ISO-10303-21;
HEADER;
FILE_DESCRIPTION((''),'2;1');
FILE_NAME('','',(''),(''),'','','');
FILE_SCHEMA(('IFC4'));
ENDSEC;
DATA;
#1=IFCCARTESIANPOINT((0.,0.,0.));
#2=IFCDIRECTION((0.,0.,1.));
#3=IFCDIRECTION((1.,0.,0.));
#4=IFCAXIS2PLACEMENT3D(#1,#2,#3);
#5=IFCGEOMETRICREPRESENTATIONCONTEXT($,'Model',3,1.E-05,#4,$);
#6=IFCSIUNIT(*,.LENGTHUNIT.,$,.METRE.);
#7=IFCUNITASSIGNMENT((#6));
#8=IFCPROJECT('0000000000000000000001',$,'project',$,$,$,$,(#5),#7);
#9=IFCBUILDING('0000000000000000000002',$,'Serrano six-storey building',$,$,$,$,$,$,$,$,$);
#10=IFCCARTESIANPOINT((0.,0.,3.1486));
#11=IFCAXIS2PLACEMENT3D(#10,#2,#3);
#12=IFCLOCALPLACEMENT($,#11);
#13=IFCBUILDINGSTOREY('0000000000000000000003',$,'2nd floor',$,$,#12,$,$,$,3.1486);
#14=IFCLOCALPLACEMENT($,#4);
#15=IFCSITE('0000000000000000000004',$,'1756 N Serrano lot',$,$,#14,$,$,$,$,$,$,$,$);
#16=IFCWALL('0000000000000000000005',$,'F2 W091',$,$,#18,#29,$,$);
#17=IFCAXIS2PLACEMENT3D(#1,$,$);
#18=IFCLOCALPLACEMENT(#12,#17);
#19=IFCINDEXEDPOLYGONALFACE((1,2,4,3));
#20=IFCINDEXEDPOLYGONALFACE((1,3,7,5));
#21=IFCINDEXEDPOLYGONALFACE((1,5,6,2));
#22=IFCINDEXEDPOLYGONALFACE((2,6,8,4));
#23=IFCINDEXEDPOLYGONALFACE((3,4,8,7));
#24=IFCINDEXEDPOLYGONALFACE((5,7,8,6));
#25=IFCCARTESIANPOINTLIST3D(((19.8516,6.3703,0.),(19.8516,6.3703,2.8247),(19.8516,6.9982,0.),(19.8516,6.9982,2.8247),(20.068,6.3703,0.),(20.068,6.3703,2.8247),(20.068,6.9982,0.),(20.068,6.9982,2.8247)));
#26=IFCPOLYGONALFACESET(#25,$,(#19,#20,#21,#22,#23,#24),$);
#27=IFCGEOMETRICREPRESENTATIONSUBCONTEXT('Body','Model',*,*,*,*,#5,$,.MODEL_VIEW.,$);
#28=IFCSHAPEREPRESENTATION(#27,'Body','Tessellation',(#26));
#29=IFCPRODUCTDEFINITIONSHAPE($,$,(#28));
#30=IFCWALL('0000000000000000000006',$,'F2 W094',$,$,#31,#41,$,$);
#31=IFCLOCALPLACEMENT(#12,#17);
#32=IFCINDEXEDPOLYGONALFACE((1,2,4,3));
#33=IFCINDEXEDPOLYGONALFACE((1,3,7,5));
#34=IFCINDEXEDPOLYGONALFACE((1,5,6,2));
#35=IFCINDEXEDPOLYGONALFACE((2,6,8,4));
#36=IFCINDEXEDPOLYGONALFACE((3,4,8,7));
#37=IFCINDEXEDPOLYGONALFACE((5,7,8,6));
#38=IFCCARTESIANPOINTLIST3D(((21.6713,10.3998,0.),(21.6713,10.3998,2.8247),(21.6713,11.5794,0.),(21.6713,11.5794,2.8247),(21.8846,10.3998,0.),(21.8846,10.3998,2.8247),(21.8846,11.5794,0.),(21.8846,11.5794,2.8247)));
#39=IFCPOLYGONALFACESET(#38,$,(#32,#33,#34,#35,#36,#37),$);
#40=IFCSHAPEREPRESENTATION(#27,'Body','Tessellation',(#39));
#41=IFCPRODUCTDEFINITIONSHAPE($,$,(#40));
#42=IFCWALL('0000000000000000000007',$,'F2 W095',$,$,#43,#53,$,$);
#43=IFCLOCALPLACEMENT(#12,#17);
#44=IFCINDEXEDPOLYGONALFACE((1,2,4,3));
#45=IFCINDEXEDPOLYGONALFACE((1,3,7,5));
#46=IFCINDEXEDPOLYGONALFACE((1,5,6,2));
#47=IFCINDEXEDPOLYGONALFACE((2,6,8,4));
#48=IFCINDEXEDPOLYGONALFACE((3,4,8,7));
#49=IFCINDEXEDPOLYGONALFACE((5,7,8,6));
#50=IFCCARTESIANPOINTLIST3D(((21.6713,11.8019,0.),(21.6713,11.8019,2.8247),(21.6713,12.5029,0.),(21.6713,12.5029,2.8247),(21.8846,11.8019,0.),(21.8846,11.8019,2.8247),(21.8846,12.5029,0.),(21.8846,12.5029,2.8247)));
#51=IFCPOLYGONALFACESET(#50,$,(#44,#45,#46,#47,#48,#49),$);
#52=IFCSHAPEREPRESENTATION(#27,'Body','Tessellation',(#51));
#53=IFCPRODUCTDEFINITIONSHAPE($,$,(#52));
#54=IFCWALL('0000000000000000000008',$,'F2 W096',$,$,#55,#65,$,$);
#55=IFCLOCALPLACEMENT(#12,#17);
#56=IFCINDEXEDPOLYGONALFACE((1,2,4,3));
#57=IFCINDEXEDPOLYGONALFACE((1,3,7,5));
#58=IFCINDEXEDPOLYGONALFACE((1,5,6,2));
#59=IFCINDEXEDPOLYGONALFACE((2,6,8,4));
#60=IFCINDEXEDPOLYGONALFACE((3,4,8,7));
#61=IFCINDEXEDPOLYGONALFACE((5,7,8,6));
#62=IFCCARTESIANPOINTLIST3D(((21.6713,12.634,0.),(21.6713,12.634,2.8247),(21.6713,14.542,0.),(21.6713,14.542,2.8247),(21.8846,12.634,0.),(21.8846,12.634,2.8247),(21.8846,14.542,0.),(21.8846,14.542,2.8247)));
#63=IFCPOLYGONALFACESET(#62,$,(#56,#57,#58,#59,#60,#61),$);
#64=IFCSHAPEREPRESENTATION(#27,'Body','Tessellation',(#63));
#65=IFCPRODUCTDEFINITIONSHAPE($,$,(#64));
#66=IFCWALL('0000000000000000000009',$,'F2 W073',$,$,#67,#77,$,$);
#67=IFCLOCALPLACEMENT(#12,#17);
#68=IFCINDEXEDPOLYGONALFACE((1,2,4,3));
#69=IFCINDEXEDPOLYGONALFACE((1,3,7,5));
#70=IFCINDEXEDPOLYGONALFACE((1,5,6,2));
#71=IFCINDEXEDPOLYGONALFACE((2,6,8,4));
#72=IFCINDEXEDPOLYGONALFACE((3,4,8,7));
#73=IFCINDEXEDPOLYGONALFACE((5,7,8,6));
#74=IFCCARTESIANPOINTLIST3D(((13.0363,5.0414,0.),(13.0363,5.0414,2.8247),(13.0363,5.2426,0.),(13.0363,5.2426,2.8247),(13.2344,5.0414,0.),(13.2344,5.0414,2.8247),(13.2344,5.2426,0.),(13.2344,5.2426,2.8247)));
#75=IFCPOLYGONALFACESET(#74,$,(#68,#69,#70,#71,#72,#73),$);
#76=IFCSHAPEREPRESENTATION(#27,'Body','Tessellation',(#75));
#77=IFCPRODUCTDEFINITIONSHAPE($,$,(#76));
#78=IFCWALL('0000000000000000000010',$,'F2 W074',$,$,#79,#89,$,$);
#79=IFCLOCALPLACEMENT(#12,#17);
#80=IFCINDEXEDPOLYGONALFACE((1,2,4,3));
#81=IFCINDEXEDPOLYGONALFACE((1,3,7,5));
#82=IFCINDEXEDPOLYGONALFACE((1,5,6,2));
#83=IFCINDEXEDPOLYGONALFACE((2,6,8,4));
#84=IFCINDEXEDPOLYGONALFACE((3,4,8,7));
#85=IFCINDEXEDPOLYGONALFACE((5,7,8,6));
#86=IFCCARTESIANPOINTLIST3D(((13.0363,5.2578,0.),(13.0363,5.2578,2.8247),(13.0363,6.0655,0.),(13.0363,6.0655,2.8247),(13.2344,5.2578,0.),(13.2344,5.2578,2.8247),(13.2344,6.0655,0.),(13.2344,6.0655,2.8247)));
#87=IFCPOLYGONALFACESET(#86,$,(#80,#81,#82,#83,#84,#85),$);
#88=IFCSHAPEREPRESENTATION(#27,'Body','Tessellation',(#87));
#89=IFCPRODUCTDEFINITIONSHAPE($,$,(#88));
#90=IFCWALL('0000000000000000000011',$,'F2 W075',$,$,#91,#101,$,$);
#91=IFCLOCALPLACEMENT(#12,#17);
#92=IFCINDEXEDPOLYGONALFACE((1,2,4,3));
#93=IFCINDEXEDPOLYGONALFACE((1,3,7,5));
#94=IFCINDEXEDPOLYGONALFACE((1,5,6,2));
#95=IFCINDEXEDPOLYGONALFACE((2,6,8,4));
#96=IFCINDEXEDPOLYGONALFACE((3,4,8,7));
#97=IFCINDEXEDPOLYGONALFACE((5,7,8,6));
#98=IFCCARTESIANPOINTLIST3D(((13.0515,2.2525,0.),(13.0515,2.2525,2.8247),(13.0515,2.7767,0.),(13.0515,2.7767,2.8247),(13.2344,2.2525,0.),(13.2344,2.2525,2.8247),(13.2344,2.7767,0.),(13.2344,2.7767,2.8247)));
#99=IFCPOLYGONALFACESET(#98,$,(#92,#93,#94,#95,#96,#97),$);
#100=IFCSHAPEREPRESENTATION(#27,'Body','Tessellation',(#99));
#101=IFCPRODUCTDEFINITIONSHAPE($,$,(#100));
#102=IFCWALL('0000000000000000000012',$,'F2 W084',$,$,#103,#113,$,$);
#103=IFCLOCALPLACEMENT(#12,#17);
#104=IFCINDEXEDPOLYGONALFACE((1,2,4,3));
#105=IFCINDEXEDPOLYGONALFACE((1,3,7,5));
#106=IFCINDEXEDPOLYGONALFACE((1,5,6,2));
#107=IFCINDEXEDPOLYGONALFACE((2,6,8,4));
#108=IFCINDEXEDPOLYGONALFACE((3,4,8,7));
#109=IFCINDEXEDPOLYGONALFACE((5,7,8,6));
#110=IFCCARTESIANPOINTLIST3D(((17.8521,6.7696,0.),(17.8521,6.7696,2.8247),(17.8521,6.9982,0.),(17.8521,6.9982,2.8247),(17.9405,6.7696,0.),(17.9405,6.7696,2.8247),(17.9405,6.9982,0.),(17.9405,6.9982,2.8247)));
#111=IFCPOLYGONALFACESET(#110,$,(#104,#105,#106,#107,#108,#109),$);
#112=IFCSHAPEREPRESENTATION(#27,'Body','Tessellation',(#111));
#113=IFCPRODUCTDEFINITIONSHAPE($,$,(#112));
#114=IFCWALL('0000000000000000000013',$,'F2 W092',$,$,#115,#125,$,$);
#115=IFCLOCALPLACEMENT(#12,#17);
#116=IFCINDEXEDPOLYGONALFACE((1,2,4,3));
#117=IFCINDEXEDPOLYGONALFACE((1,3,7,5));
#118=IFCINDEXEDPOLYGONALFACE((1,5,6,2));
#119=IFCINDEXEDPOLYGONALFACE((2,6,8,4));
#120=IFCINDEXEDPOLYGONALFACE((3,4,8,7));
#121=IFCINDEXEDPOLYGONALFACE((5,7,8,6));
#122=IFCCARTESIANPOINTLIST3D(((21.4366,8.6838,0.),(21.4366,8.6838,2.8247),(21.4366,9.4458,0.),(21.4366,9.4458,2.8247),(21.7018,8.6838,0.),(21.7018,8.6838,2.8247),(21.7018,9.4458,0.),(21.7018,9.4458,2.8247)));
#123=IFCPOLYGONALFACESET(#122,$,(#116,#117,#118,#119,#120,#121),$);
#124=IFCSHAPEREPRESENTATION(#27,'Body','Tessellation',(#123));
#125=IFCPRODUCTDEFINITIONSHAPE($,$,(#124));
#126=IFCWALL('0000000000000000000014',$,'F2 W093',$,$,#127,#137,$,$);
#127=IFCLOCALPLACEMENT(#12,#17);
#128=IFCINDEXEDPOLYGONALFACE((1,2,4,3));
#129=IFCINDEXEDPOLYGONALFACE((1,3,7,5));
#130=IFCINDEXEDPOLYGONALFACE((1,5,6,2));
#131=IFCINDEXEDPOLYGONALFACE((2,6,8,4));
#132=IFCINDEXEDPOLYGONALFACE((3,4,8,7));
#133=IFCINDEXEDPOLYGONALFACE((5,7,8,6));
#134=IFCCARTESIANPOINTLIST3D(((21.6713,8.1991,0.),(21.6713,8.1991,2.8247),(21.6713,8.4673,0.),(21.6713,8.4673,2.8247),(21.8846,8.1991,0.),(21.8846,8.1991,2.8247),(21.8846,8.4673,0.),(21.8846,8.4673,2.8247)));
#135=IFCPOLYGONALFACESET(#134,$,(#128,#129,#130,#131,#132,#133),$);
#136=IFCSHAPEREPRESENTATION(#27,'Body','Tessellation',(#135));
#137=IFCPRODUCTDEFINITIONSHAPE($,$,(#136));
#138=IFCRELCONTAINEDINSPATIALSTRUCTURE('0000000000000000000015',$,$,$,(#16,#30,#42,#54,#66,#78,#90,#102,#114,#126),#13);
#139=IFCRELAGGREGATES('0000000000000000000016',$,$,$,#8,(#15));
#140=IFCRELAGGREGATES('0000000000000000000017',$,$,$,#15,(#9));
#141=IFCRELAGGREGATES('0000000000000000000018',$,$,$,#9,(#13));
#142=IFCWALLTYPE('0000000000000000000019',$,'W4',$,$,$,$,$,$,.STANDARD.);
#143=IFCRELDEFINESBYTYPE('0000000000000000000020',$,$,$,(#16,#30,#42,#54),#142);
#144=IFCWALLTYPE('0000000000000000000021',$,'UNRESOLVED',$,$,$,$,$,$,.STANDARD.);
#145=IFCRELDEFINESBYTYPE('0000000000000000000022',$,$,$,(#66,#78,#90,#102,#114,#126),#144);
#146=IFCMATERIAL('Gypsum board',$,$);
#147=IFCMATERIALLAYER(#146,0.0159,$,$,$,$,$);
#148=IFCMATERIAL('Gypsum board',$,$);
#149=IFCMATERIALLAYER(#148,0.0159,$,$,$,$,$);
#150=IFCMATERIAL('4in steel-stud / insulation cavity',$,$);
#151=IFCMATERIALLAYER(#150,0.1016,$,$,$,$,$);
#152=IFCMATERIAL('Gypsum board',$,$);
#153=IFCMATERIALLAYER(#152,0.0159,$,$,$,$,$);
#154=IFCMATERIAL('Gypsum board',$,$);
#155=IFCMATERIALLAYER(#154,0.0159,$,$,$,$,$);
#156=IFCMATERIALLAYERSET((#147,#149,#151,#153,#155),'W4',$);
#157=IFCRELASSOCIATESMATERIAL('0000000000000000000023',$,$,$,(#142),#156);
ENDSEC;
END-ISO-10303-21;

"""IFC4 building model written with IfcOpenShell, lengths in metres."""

from ifc_helpers import new_model, si_unit, frame, origin_with_axes, place, context, subcontext, project, spatial, polyline, outline, extrude, material, layer, layer_set, type_object, element, save


model = new_model("IFC4")

# Units and contexts
model_context = context("Model", 3, precision=1e-05, world=origin_with_axes())
body_context = subcontext(model_context, "Body", "Model", "MODEL_VIEW")
ifc_project = project(units=[si_unit("LENGTHUNIT", "METRE")], contexts=[model_context])

# Site, building, storey
site_placement = place(None, origin_with_axes())
site = spatial("IfcSite", under=ifc_project, at=site_placement, Name="1756 N Serrano lot")
building = spatial("IfcBuilding", under=site, Name="Serrano six-storey building")
storey_placement = place(None, frame((0.0, 0.0, 3.1486), z_axis=(0.0, 0.0, 1.0), x_axis=(1.0, 0.0, 0.0)))
storey = spatial("IfcBuildingStorey", under=building, at=storey_placement, Name="2nd floor", Elevation=3.1486)

# Walls
ifc_material_1 = material(Name="Gypsum board")
ifc_layer_1 = layer(ifc_material_1, 0.0159)
ifc_material_2 = material(Name="Gypsum board")
ifc_layer_2 = layer(ifc_material_2, 0.0159)
ifc_material_3 = material(Name="4in steel-stud / insulation cavity")
ifc_layer_3 = layer(ifc_material_3, 0.1016)
ifc_material_4 = material(Name="Gypsum board")
ifc_layer_4 = layer(ifc_material_4, 0.0159)
ifc_material_5 = material(Name="Gypsum board")
ifc_layer_5 = layer(ifc_material_5, 0.0159)
ifc_layer_set_1 = layer_set([ifc_layer_1, ifc_layer_2, ifc_layer_3, ifc_layer_4, ifc_layer_5], Name="W4")
wall_type_1 = type_object("IfcWallType", Name="W4", PredefinedType="STANDARD", material=ifc_layer_set_1)
wall_1_placement = place(storey_placement, frame((0.0, 0.0, -3.1486), z_axis=(0.0, 0.0, 1.0), x_axis=(1.0, 0.0, 0.0)))
element("IfcWall", 1, at=wall_1_placement, inside=storey, type_object=wall_type_1, Name="F2 W091", context=body_context, shape_type="SweptSolid", body=[
    extrude(outline(polyline([(19.8516, 6.9982), (20.068, 6.9982), (20.068, 6.3703), (19.8516, 6.3703), (19.8516, 6.9982)])), frame((0.0, 0.0, 3.1486)), (0.0, 0.0, 1.0), 2.8247),
])
wall_2_placement = place(storey_placement, frame((0.0, 0.0, -3.1486), z_axis=(0.0, 0.0, 1.0), x_axis=(1.0, 0.0, 0.0)))
element("IfcWall", 2, at=wall_2_placement, inside=storey, type_object=wall_type_1, Name="F2 W094", context=body_context, shape_type="SweptSolid", body=[
    extrude(outline(polyline([(21.6713, 11.5794), (21.8846, 11.5794), (21.8846, 10.3998), (21.6713, 10.3998), (21.6713, 11.5794)])), frame((0.0, 0.0, 3.1486)), (0.0, 0.0, 1.0), 2.8247),
])
wall_3_placement = place(storey_placement, frame((0.0, 0.0, -3.1486), z_axis=(0.0, 0.0, 1.0), x_axis=(1.0, 0.0, 0.0)))
element("IfcWall", 3, at=wall_3_placement, inside=storey, type_object=wall_type_1, Name="F2 W095", context=body_context, shape_type="SweptSolid", body=[
    extrude(outline(polyline([(21.6713, 12.5029), (21.8846, 12.5029), (21.8846, 11.8019), (21.6713, 11.8019), (21.6713, 12.5029)])), frame((0.0, 0.0, 3.1486)), (0.0, 0.0, 1.0), 2.8247),
])
wall_4_placement = place(storey_placement, frame((0.0, 0.0, -3.1486), z_axis=(0.0, 0.0, 1.0), x_axis=(1.0, 0.0, 0.0)))
element("IfcWall", 4, at=wall_4_placement, inside=storey, type_object=wall_type_1, Name="F2 W096", context=body_context, shape_type="SweptSolid", body=[
    extrude(outline(polyline([(21.6713, 14.542), (21.8846, 14.542), (21.8846, 12.634), (21.6713, 12.634), (21.6713, 14.542)])), frame((0.0, 0.0, 3.1486)), (0.0, 0.0, 1.0), 2.8247),
])
wall_type_2 = type_object("IfcWallType", Name="UNRESOLVED", PredefinedType="STANDARD")
wall_5_placement = place(storey_placement, frame((0.0, 0.0, -3.1486), z_axis=(0.0, 0.0, 1.0), x_axis=(1.0, 0.0, 0.0)))
element("IfcWall", 5, at=wall_5_placement, inside=storey, type_object=wall_type_2, Name="F2 W073", context=body_context, shape_type="SweptSolid", body=[
    extrude(outline(polyline([(13.0363, 5.2426), (13.2344, 5.2426), (13.2344, 5.0414), (13.0363, 5.0414), (13.0363, 5.2426)])), frame((0.0, 0.0, 3.1486)), (0.0, 0.0, 1.0), 2.8247),
])
wall_6_placement = place(storey_placement, frame((0.0, 0.0, -3.1486), z_axis=(0.0, 0.0, 1.0), x_axis=(1.0, 0.0, 0.0)))
element("IfcWall", 6, at=wall_6_placement, inside=storey, type_object=wall_type_2, Name="F2 W074", context=body_context, shape_type="SweptSolid", body=[
    extrude(outline(polyline([(13.0363, 6.0655), (13.2344, 6.0655), (13.2344, 5.2578), (13.0363, 5.2578), (13.0363, 6.0655)])), frame((0.0, 0.0, 3.1486)), (0.0, 0.0, 1.0), 2.8247),
])
wall_7_placement = place(storey_placement, frame((0.0, 0.0, -3.1486), z_axis=(0.0, 0.0, 1.0), x_axis=(1.0, 0.0, 0.0)))
element("IfcWall", 7, at=wall_7_placement, inside=storey, type_object=wall_type_2, Name="F2 W075", context=body_context, shape_type="SweptSolid", body=[
    extrude(outline(polyline([(13.0515, 2.7767), (13.2344, 2.7767), (13.2344, 2.2525), (13.0515, 2.2525), (13.0515, 2.7767)])), frame((0.0, 0.0, 3.1486)), (0.0, 0.0, 1.0), 2.8247),
])
wall_8_placement = place(storey_placement, frame((0.0, 0.0, -3.1486), z_axis=(0.0, 0.0, 1.0), x_axis=(1.0, 0.0, 0.0)))
element("IfcWall", 8, at=wall_8_placement, inside=storey, type_object=wall_type_2, Name="F2 W084", context=body_context, shape_type="SweptSolid", body=[
    extrude(outline(polyline([(17.8521, 6.9982), (17.9405, 6.9982), (17.9405, 6.7696), (17.8521, 6.7696), (17.8521, 6.9982)])), frame((0.0, 0.0, 3.1486)), (0.0, 0.0, 1.0), 2.8247),
])
wall_9_placement = place(storey_placement, frame((0.0, 0.0, -3.1486), z_axis=(0.0, 0.0, 1.0), x_axis=(1.0, 0.0, 0.0)))
element("IfcWall", 9, at=wall_9_placement, inside=storey, type_object=wall_type_2, Name="F2 W092", context=body_context, shape_type="SweptSolid", body=[
    extrude(outline(polyline([(21.4366, 9.4458), (21.7018, 9.4458), (21.7018, 8.6838), (21.4366, 8.6838), (21.4366, 9.4458)])), frame((0.0, 0.0, 3.1486)), (0.0, 0.0, 1.0), 2.8247),
])
wall_10_placement = place(storey_placement, frame((0.0, 0.0, -3.1486), z_axis=(0.0, 0.0, 1.0), x_axis=(1.0, 0.0, 0.0)))
element("IfcWall", 10, at=wall_10_placement, inside=storey, type_object=wall_type_2, Name="F2 W093", context=body_context, shape_type="SweptSolid", body=[
    extrude(outline(polyline([(21.6713, 8.4673), (21.8846, 8.4673), (21.8846, 8.1991), (21.6713, 8.1991), (21.6713, 8.4673)])), frame((0.0, 0.0, 3.1486)), (0.0, 0.0, 1.0), 2.8247),
])

save(model, "model.ifc")
